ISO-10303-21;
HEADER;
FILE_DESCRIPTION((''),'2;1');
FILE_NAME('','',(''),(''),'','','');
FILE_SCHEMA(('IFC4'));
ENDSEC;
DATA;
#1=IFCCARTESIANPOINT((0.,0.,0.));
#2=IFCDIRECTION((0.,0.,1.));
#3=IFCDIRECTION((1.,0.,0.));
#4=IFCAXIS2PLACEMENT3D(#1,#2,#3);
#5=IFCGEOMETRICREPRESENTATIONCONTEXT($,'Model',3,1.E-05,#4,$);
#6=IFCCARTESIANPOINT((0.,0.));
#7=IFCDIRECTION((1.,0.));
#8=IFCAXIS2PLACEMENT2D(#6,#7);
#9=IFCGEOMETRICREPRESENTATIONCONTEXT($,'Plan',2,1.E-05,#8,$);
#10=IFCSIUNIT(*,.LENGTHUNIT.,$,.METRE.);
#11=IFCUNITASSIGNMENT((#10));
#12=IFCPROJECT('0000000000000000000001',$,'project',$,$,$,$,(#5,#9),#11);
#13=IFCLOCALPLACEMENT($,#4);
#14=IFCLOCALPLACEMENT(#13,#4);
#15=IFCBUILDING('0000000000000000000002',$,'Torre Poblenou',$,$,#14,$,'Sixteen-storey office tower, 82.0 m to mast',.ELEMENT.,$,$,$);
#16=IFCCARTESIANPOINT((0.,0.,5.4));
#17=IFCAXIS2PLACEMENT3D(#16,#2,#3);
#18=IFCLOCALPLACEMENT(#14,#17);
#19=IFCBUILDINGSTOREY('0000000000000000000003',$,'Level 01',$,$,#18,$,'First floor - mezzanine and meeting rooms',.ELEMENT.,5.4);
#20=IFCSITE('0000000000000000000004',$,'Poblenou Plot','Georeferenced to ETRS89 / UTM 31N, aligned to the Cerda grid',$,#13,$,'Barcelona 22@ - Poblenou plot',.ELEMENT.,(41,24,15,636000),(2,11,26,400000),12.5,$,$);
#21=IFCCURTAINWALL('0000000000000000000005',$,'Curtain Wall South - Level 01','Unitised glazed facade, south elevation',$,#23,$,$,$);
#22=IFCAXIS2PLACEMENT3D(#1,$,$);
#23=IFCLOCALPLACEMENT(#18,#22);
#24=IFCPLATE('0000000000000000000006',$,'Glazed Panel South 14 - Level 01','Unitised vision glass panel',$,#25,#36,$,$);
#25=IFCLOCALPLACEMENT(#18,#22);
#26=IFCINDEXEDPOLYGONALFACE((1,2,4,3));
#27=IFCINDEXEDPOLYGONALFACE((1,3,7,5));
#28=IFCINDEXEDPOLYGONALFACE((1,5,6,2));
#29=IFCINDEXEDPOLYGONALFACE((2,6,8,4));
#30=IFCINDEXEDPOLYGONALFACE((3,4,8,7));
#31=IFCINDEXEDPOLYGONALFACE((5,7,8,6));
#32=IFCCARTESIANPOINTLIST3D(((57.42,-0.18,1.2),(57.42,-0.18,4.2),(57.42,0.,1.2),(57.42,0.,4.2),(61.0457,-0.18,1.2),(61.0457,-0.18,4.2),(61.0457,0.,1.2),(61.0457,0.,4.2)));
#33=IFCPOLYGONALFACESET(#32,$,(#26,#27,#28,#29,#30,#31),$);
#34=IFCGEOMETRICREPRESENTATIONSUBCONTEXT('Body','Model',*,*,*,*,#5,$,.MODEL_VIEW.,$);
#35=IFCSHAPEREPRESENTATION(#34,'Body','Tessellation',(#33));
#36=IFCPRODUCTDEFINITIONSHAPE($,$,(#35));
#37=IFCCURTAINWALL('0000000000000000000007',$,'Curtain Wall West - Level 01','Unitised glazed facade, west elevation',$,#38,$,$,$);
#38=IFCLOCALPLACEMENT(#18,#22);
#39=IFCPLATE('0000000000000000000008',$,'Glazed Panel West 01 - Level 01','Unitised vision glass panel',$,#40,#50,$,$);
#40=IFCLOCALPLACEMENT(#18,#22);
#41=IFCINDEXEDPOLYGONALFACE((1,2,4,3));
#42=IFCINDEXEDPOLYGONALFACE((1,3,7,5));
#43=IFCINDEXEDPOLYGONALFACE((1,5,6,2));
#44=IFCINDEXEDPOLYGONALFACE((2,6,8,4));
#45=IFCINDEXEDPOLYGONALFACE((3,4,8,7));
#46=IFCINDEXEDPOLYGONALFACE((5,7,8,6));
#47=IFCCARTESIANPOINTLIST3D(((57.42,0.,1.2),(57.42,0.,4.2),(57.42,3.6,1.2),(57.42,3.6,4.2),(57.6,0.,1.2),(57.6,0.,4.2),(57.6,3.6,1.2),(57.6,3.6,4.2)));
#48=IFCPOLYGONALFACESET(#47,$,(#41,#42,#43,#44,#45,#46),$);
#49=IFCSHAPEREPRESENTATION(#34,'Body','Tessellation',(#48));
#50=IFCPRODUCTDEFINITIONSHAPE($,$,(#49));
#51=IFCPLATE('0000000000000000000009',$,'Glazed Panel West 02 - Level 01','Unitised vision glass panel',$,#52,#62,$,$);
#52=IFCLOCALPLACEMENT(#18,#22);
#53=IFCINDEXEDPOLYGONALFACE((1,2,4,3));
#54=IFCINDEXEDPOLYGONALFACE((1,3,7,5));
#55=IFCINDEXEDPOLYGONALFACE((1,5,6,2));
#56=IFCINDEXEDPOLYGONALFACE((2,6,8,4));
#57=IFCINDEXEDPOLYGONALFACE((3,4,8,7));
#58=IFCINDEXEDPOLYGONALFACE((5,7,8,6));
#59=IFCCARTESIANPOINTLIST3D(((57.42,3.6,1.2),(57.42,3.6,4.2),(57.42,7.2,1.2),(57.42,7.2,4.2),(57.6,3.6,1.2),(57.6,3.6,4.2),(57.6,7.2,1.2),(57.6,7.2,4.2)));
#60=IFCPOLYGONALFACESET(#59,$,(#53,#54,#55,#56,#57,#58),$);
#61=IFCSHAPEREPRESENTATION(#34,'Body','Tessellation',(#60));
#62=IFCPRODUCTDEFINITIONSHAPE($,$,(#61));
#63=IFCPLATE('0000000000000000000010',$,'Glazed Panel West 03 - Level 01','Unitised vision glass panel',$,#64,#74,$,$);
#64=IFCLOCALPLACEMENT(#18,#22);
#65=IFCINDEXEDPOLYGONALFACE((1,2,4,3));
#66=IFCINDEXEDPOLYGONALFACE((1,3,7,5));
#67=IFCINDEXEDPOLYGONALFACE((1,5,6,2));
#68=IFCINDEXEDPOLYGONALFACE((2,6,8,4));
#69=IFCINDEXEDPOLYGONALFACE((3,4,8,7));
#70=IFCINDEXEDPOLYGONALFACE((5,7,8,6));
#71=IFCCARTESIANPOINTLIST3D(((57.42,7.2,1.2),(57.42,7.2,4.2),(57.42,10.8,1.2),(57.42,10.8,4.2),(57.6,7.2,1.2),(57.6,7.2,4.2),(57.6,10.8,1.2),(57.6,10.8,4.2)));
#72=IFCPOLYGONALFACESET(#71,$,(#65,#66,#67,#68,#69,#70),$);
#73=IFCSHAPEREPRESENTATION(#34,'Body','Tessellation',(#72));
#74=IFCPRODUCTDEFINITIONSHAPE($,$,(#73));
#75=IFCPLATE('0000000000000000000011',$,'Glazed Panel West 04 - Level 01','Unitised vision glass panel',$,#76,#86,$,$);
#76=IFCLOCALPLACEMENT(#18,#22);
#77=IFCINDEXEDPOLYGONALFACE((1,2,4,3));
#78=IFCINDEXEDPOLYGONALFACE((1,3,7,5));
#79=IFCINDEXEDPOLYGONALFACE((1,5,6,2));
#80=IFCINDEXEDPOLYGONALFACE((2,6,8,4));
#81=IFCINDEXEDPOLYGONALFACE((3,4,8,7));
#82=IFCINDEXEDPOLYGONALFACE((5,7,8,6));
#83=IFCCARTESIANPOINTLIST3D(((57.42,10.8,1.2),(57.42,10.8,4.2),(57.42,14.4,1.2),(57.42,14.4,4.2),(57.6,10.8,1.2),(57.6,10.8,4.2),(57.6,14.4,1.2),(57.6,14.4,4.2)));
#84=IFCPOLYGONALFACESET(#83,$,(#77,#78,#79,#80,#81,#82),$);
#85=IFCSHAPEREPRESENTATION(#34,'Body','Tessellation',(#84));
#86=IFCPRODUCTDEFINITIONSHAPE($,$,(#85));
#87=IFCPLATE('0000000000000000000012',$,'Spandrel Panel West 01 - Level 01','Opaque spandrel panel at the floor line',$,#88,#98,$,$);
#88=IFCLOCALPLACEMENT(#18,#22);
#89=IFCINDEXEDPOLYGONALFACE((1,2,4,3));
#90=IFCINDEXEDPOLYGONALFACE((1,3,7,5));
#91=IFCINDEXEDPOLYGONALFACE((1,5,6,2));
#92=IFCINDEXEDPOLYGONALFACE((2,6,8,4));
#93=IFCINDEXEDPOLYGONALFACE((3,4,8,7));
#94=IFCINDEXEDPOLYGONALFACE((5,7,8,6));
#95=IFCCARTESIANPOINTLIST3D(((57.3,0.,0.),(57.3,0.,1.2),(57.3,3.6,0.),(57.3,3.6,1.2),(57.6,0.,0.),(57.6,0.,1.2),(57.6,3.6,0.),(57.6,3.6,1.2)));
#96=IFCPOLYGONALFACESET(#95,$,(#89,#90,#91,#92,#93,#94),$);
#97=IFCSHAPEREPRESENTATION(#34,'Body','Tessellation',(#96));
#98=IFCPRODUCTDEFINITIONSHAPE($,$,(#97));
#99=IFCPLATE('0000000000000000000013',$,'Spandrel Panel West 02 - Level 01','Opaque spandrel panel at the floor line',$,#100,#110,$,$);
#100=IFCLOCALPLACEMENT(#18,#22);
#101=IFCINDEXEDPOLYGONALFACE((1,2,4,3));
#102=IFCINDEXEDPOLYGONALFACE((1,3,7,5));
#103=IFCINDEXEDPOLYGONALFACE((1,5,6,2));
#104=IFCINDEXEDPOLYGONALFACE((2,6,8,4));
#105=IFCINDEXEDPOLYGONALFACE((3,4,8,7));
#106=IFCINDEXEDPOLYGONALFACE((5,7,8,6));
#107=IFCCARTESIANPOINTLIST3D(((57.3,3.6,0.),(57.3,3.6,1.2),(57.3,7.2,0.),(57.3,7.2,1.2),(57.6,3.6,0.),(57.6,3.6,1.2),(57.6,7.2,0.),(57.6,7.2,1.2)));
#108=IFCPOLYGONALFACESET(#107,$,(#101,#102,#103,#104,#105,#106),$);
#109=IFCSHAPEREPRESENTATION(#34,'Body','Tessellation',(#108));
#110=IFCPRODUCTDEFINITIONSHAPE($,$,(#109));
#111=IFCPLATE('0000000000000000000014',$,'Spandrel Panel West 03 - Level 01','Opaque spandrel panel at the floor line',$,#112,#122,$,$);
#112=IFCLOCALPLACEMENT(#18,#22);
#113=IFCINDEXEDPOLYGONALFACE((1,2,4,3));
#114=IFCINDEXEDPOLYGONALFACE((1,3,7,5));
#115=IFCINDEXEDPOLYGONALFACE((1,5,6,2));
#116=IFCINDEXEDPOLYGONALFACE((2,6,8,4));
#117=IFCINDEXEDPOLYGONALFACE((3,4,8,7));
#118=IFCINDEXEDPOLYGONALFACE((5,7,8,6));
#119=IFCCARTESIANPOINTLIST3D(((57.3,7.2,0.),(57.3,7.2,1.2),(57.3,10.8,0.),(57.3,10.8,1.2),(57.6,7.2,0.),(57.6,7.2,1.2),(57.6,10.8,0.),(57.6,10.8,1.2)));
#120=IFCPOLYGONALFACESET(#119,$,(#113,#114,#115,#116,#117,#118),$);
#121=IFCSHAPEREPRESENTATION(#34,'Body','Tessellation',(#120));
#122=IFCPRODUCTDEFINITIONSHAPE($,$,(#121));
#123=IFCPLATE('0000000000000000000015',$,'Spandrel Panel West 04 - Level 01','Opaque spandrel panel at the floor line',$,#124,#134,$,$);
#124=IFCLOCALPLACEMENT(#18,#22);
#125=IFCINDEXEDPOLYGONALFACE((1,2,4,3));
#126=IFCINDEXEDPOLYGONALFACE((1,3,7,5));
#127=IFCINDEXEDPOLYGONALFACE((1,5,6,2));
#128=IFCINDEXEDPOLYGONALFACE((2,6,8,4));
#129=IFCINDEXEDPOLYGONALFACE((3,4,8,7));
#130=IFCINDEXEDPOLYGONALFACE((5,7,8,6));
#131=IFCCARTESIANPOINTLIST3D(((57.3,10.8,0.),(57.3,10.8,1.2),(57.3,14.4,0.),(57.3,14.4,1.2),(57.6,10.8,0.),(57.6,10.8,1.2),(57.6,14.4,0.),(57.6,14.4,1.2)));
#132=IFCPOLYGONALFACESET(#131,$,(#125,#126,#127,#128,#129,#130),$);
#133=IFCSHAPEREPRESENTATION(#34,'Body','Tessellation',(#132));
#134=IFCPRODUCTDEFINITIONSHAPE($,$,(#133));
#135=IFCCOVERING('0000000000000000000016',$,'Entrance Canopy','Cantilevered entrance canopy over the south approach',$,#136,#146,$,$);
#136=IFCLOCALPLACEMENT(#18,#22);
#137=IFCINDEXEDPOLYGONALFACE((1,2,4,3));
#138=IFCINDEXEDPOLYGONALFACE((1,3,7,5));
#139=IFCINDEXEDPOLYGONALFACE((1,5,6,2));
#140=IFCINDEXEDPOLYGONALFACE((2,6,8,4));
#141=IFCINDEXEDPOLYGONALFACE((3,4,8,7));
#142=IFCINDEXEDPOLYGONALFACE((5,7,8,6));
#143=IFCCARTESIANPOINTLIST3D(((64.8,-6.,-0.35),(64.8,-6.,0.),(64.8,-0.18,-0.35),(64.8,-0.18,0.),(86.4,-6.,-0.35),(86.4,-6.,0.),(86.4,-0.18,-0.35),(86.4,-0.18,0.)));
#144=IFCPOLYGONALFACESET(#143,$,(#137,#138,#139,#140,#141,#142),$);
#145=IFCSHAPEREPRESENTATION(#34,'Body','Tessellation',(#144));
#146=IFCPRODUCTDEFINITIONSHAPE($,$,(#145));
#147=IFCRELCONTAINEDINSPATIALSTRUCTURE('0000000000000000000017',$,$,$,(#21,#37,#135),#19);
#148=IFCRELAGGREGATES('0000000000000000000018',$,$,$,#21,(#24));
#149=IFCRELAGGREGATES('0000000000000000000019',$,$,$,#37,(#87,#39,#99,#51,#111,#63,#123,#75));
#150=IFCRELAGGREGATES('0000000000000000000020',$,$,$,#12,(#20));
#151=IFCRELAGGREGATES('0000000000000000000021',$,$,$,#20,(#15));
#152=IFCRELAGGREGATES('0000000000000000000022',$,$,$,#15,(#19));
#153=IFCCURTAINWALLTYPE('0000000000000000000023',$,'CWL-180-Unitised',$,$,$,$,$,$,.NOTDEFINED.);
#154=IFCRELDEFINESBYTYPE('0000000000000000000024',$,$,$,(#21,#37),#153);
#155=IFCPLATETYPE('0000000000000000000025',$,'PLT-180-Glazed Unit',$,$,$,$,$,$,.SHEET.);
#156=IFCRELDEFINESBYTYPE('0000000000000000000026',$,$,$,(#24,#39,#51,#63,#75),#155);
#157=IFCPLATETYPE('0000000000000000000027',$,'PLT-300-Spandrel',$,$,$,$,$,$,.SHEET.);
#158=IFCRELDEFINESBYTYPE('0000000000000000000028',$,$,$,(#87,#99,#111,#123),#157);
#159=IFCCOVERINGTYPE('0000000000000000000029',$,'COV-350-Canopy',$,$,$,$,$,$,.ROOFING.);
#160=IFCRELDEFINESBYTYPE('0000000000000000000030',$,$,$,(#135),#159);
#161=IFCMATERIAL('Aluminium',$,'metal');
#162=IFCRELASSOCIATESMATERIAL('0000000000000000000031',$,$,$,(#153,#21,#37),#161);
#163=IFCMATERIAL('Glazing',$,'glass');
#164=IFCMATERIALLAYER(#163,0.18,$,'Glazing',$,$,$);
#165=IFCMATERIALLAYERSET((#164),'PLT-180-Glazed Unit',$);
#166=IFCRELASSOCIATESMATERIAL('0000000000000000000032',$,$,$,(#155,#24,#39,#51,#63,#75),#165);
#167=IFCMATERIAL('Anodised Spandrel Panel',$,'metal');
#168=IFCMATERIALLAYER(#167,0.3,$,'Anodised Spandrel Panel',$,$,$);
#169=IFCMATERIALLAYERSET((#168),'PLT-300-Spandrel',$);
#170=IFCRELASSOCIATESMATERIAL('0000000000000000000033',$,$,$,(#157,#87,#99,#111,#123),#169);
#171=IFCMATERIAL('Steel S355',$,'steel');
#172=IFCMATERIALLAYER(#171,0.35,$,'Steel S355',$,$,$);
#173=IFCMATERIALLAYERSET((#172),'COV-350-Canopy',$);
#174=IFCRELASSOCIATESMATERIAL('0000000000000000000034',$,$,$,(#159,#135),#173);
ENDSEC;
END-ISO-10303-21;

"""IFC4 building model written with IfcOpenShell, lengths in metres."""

from ifc_helpers import new_model, si_unit, frame, origin_with_axes, origin_2d_with_axis, place, context, subcontext, project, spatial, line, indexed_curve, outline, extrude, material, layer, layer_set, layer_usage, type_object, element, aggregate, save


model = new_model("IFC4")

# Units and contexts
model_context = context("Model", 3, precision=1e-05, world=origin_with_axes())
plan_context = context("Plan", 2, precision=1e-05, world=origin_2d_with_axis())
body_context = subcontext(model_context, "Body", "Model", "MODEL_VIEW")
ifc_project = project(units=[si_unit("LENGTHUNIT", "METRE")], contexts=[model_context, plan_context])

# Site, building, storey
site_placement = place(None, origin_with_axes())
site = spatial("IfcSite", under=ifc_project, at=site_placement, Name="Poblenou Plot", Description="Georeferenced to ETRS89 / UTM 31N, aligned to the Cerda grid", LongName="Barcelona 22@ - Poblenou plot", CompositionType="ELEMENT", RefLatitude=(41, 24, 15, 636000), RefLongitude=(2, 11, 26, 400000), RefElevation=12.5)
building_placement = place(site_placement, origin_with_axes())
building = spatial("IfcBuilding", under=site, at=building_placement, Name="Torre Poblenou", LongName="Sixteen-storey office tower, 82.0 m to mast", CompositionType="ELEMENT")
storey_placement = place(building_placement, frame((0.0, 0.0, 5.4), z_axis=(0.0, 0.0, 1.0), x_axis=(1.0, 0.0, 0.0)))
storey = spatial("IfcBuildingStorey", under=building, at=storey_placement, Name="Level 01", LongName="First floor - mezzanine and meeting rooms", CompositionType="ELEMENT", Elevation=5.4)

# Curtain walls, plates
ifc_material_1 = material(Name="Aluminium", Category="metal")
curtain_wall_type = type_object("IfcCurtainWallType", Name="CWL-180-Unitised", PredefinedType="NOTDEFINED", material=ifc_material_1)
curtain_wall_1_placement = place(storey_placement, frame((108.18, 0.0, 0.0), z_axis=(0.0, 0.0, 1.0), x_axis=(-1.0, 0.0, 0.0)))
curtain_wall_1 = element("IfcCurtainWall", 1, at=curtain_wall_1_placement, inside=storey, type_object=curtain_wall_type, material=ifc_material_1, Name="Curtain Wall South - Level 01", Description="Unitised glazed facade, south elevation")
ifc_material_2 = material(Name="Glazing", Category="glass")
ifc_layer_1 = layer(ifc_material_2, 0.18, Name="Glazing")
ifc_layer_set_1 = layer_set([ifc_layer_1], Name="PLT-180-Glazed Unit")
plate_type_1 = type_object("IfcPlateType", Name="PLT-180-Glazed Unit", PredefinedType="SHEET", material=ifc_layer_set_1)
ifc_layer_usage_1 = layer_usage(ifc_layer_set_1, "AXIS2", "POSITIVE", 0.0)
plate_1_placement = place(curtain_wall_1_placement, frame((47.1343, 0.0, 1.2), z_axis=(0.0, 0.0, 1.0), x_axis=(1.0, 0.0, 0.0)))
plate_1 = element("IfcPlate", 2, at=plate_1_placement, type_object=plate_type_1, material=ifc_layer_usage_1, Name="Glazed Panel South 14 - Level 01", Description="Unitised vision glass panel", context=body_context, shape_type="SweptSolid", body=[
    extrude(outline(indexed_curve([(0.0, 0.0), (3.6257, 0.0), (3.6257, 0.18), (0.0, 0.18)], segments=[line(1, 2, 3, 4, 1)])), origin_with_axes(), (0.0, 0.0, 1.0), 3.0),
])
curtain_wall_2_placement = place(storey_placement, frame((57.6, 0.0, 0.0), z_axis=(0.0, 0.0, 1.0), x_axis=(0.0, 1.0, 0.0)))
curtain_wall_2 = element("IfcCurtainWall", 3, at=curtain_wall_2_placement, inside=storey, type_object=curtain_wall_type, material=ifc_material_1, Name="Curtain Wall West - Level 01", Description="Unitised glazed facade, west elevation")
ifc_layer_usage_2 = layer_usage(ifc_layer_set_1, "AXIS2", "POSITIVE", 0.0)
plate_2_placement = place(curtain_wall_2_placement, frame((0.0, 0.0, 1.2), z_axis=(0.0, 0.0, 1.0), x_axis=(1.0, 0.0, 0.0)))
plate_2 = element("IfcPlate", 4, at=plate_2_placement, type_object=plate_type_1, material=ifc_layer_usage_2, Name="Glazed Panel West 01 - Level 01", Description="Unitised vision glass panel", context=body_context, shape_type="SweptSolid", body=[
    extrude(outline(indexed_curve([(0.0, 0.0), (3.6, 0.0), (3.6, 0.18), (0.0, 0.18)], segments=[line(1, 2, 3, 4, 1)])), origin_with_axes(), (0.0, 0.0, 1.0), 3.0),
])
ifc_layer_usage_3 = layer_usage(ifc_layer_set_1, "AXIS2", "POSITIVE", 0.0)
plate_3_placement = place(curtain_wall_2_placement, frame((3.6, 0.0, 1.2), z_axis=(0.0, 0.0, 1.0), x_axis=(1.0, 0.0, 0.0)))
plate_3 = element("IfcPlate", 5, at=plate_3_placement, type_object=plate_type_1, material=ifc_layer_usage_3, Name="Glazed Panel West 02 - Level 01", Description="Unitised vision glass panel", context=body_context, shape_type="SweptSolid", body=[
    extrude(outline(indexed_curve([(0.0, 0.0), (3.6, 0.0), (3.6, 0.18), (0.0, 0.18)], segments=[line(1, 2, 3, 4, 1)])), origin_with_axes(), (0.0, 0.0, 1.0), 3.0),
])
ifc_layer_usage_4 = layer_usage(ifc_layer_set_1, "AXIS2", "POSITIVE", 0.0)
plate_4_placement = place(curtain_wall_2_placement, frame((7.2, 0.0, 1.2), z_axis=(0.0, 0.0, 1.0), x_axis=(1.0, 0.0, 0.0)))
plate_4 = element("IfcPlate", 6, at=plate_4_placement, type_object=plate_type_1, material=ifc_layer_usage_4, Name="Glazed Panel West 03 - Level 01", Description="Unitised vision glass panel", context=body_context, shape_type="SweptSolid", body=[
    extrude(outline(indexed_curve([(0.0, 0.0), (3.6, 0.0), (3.6, 0.18), (0.0, 0.18)], segments=[line(1, 2, 3, 4, 1)])), origin_with_axes(), (0.0, 0.0, 1.0), 3.0),
])
ifc_layer_usage_5 = layer_usage(ifc_layer_set_1, "AXIS2", "POSITIVE", 0.0)
plate_5_placement = place(curtain_wall_2_placement, frame((10.8, 0.0, 1.2), z_axis=(0.0, 0.0, 1.0), x_axis=(1.0, 0.0, 0.0)))
plate_5 = element("IfcPlate", 7, at=plate_5_placement, type_object=plate_type_1, material=ifc_layer_usage_5, Name="Glazed Panel West 04 - Level 01", Description="Unitised vision glass panel", context=body_context, shape_type="SweptSolid", body=[
    extrude(outline(indexed_curve([(0.0, 0.0), (3.6, 0.0), (3.6, 0.18), (0.0, 0.18)], segments=[line(1, 2, 3, 4, 1)])), origin_with_axes(), (0.0, 0.0, 1.0), 3.0),
])

# Plates
ifc_material_3 = material(Name="Anodised Spandrel Panel", Category="metal")
ifc_layer_2 = layer(ifc_material_3, 0.3, Name="Anodised Spandrel Panel")
ifc_layer_set_2 = layer_set([ifc_layer_2], Name="PLT-300-Spandrel")
plate_type_2 = type_object("IfcPlateType", Name="PLT-300-Spandrel", PredefinedType="SHEET", material=ifc_layer_set_2)
aggregate(curtain_wall_1, [plate_1])
ifc_layer_usage_6 = layer_usage(ifc_layer_set_2, "AXIS2", "POSITIVE", 0.0)
plate_6_placement = place(curtain_wall_2_placement, origin_with_axes())
plate_6 = element("IfcPlate", 8, at=plate_6_placement, type_object=plate_type_2, material=ifc_layer_usage_6, Name="Spandrel Panel West 01 - Level 01", Description="Opaque spandrel panel at the floor line", context=body_context, shape_type="SweptSolid", body=[
    extrude(outline(indexed_curve([(0.0, 0.0), (3.6, 0.0), (3.6, 0.3), (0.0, 0.3)], segments=[line(1, 2, 3, 4, 1)])), origin_with_axes(), (0.0, 0.0, 1.0), 1.2),
])
ifc_layer_usage_7 = layer_usage(ifc_layer_set_2, "AXIS2", "POSITIVE", 0.0)
plate_7_placement = place(curtain_wall_2_placement, frame((3.6, 0.0, 0.0), z_axis=(0.0, 0.0, 1.0), x_axis=(1.0, 0.0, 0.0)))
plate_7 = element("IfcPlate", 9, at=plate_7_placement, type_object=plate_type_2, material=ifc_layer_usage_7, Name="Spandrel Panel West 02 - Level 01", Description="Opaque spandrel panel at the floor line", context=body_context, shape_type="SweptSolid", body=[
    extrude(outline(indexed_curve([(0.0, 0.0), (3.6, 0.0), (3.6, 0.3), (0.0, 0.3)], segments=[line(1, 2, 3, 4, 1)])), origin_with_axes(), (0.0, 0.0, 1.0), 1.2),
])
ifc_layer_usage_8 = layer_usage(ifc_layer_set_2, "AXIS2", "POSITIVE", 0.0)
plate_8_placement = place(curtain_wall_2_placement, frame((7.2, 0.0, 0.0), z_axis=(0.0, 0.0, 1.0), x_axis=(1.0, 0.0, 0.0)))
plate_8 = element("IfcPlate", 10, at=plate_8_placement, type_object=plate_type_2, material=ifc_layer_usage_8, Name="Spandrel Panel West 03 - Level 01", Description="Opaque spandrel panel at the floor line", context=body_context, shape_type="SweptSolid", body=[
    extrude(outline(indexed_curve([(0.0, 0.0), (3.6, 0.0), (3.6, 0.3), (0.0, 0.3)], segments=[line(1, 2, 3, 4, 1)])), origin_with_axes(), (0.0, 0.0, 1.0), 1.2),
])
ifc_layer_usage_9 = layer_usage(ifc_layer_set_2, "AXIS2", "POSITIVE", 0.0)
plate_9_placement = place(curtain_wall_2_placement, frame((10.8, 0.0, 0.0), z_axis=(0.0, 0.0, 1.0), x_axis=(1.0, 0.0, 0.0)))
plate_9 = element("IfcPlate", 11, at=plate_9_placement, type_object=plate_type_2, material=ifc_layer_usage_9, Name="Spandrel Panel West 04 - Level 01", Description="Opaque spandrel panel at the floor line", context=body_context, shape_type="SweptSolid", body=[
    extrude(outline(indexed_curve([(0.0, 0.0), (3.6, 0.0), (3.6, 0.3), (0.0, 0.3)], segments=[line(1, 2, 3, 4, 1)])), origin_with_axes(), (0.0, 0.0, 1.0), 1.2),
])
aggregate(curtain_wall_2, [plate_6, plate_2, plate_7, plate_3, plate_8, plate_4, plate_9, plate_5])

# Covering
ifc_material_4 = material(Name="Steel S355", Category="steel")
ifc_layer_3 = layer(ifc_material_4, 0.35, Name="Steel S355")
ifc_layer_set_3 = layer_set([ifc_layer_3], Name="COV-350-Canopy")
ifc_layer_usage_10 = layer_usage(ifc_layer_set_3, "AXIS3", "POSITIVE", 0.0)
covering_type = type_object("IfcCoveringType", Name="COV-350-Canopy", PredefinedType="ROOFING", material=ifc_layer_set_3)
covering_placement = place(storey_placement, frame((64.8, -6.0, -0.35), z_axis=(0.0, 0.0, 1.0), x_axis=(1.0, 0.0, 0.0)))
element("IfcCovering", 12, at=covering_placement, inside=storey, type_object=covering_type, material=ifc_layer_usage_10, Name="Entrance Canopy", Description="Cantilevered entrance canopy over the south approach", context=body_context, shape_type="SweptSolid", body=[
    extrude(outline(indexed_curve([(0.0, 0.0), (21.6, 0.0), (21.6, 5.82), (0.0, 5.82)], segments=[line(1, 2, 3, 4, 1)])), origin_with_axes(), (0.0, 0.0, 1.0), 0.35),
])

save(model, "model.ifc")
